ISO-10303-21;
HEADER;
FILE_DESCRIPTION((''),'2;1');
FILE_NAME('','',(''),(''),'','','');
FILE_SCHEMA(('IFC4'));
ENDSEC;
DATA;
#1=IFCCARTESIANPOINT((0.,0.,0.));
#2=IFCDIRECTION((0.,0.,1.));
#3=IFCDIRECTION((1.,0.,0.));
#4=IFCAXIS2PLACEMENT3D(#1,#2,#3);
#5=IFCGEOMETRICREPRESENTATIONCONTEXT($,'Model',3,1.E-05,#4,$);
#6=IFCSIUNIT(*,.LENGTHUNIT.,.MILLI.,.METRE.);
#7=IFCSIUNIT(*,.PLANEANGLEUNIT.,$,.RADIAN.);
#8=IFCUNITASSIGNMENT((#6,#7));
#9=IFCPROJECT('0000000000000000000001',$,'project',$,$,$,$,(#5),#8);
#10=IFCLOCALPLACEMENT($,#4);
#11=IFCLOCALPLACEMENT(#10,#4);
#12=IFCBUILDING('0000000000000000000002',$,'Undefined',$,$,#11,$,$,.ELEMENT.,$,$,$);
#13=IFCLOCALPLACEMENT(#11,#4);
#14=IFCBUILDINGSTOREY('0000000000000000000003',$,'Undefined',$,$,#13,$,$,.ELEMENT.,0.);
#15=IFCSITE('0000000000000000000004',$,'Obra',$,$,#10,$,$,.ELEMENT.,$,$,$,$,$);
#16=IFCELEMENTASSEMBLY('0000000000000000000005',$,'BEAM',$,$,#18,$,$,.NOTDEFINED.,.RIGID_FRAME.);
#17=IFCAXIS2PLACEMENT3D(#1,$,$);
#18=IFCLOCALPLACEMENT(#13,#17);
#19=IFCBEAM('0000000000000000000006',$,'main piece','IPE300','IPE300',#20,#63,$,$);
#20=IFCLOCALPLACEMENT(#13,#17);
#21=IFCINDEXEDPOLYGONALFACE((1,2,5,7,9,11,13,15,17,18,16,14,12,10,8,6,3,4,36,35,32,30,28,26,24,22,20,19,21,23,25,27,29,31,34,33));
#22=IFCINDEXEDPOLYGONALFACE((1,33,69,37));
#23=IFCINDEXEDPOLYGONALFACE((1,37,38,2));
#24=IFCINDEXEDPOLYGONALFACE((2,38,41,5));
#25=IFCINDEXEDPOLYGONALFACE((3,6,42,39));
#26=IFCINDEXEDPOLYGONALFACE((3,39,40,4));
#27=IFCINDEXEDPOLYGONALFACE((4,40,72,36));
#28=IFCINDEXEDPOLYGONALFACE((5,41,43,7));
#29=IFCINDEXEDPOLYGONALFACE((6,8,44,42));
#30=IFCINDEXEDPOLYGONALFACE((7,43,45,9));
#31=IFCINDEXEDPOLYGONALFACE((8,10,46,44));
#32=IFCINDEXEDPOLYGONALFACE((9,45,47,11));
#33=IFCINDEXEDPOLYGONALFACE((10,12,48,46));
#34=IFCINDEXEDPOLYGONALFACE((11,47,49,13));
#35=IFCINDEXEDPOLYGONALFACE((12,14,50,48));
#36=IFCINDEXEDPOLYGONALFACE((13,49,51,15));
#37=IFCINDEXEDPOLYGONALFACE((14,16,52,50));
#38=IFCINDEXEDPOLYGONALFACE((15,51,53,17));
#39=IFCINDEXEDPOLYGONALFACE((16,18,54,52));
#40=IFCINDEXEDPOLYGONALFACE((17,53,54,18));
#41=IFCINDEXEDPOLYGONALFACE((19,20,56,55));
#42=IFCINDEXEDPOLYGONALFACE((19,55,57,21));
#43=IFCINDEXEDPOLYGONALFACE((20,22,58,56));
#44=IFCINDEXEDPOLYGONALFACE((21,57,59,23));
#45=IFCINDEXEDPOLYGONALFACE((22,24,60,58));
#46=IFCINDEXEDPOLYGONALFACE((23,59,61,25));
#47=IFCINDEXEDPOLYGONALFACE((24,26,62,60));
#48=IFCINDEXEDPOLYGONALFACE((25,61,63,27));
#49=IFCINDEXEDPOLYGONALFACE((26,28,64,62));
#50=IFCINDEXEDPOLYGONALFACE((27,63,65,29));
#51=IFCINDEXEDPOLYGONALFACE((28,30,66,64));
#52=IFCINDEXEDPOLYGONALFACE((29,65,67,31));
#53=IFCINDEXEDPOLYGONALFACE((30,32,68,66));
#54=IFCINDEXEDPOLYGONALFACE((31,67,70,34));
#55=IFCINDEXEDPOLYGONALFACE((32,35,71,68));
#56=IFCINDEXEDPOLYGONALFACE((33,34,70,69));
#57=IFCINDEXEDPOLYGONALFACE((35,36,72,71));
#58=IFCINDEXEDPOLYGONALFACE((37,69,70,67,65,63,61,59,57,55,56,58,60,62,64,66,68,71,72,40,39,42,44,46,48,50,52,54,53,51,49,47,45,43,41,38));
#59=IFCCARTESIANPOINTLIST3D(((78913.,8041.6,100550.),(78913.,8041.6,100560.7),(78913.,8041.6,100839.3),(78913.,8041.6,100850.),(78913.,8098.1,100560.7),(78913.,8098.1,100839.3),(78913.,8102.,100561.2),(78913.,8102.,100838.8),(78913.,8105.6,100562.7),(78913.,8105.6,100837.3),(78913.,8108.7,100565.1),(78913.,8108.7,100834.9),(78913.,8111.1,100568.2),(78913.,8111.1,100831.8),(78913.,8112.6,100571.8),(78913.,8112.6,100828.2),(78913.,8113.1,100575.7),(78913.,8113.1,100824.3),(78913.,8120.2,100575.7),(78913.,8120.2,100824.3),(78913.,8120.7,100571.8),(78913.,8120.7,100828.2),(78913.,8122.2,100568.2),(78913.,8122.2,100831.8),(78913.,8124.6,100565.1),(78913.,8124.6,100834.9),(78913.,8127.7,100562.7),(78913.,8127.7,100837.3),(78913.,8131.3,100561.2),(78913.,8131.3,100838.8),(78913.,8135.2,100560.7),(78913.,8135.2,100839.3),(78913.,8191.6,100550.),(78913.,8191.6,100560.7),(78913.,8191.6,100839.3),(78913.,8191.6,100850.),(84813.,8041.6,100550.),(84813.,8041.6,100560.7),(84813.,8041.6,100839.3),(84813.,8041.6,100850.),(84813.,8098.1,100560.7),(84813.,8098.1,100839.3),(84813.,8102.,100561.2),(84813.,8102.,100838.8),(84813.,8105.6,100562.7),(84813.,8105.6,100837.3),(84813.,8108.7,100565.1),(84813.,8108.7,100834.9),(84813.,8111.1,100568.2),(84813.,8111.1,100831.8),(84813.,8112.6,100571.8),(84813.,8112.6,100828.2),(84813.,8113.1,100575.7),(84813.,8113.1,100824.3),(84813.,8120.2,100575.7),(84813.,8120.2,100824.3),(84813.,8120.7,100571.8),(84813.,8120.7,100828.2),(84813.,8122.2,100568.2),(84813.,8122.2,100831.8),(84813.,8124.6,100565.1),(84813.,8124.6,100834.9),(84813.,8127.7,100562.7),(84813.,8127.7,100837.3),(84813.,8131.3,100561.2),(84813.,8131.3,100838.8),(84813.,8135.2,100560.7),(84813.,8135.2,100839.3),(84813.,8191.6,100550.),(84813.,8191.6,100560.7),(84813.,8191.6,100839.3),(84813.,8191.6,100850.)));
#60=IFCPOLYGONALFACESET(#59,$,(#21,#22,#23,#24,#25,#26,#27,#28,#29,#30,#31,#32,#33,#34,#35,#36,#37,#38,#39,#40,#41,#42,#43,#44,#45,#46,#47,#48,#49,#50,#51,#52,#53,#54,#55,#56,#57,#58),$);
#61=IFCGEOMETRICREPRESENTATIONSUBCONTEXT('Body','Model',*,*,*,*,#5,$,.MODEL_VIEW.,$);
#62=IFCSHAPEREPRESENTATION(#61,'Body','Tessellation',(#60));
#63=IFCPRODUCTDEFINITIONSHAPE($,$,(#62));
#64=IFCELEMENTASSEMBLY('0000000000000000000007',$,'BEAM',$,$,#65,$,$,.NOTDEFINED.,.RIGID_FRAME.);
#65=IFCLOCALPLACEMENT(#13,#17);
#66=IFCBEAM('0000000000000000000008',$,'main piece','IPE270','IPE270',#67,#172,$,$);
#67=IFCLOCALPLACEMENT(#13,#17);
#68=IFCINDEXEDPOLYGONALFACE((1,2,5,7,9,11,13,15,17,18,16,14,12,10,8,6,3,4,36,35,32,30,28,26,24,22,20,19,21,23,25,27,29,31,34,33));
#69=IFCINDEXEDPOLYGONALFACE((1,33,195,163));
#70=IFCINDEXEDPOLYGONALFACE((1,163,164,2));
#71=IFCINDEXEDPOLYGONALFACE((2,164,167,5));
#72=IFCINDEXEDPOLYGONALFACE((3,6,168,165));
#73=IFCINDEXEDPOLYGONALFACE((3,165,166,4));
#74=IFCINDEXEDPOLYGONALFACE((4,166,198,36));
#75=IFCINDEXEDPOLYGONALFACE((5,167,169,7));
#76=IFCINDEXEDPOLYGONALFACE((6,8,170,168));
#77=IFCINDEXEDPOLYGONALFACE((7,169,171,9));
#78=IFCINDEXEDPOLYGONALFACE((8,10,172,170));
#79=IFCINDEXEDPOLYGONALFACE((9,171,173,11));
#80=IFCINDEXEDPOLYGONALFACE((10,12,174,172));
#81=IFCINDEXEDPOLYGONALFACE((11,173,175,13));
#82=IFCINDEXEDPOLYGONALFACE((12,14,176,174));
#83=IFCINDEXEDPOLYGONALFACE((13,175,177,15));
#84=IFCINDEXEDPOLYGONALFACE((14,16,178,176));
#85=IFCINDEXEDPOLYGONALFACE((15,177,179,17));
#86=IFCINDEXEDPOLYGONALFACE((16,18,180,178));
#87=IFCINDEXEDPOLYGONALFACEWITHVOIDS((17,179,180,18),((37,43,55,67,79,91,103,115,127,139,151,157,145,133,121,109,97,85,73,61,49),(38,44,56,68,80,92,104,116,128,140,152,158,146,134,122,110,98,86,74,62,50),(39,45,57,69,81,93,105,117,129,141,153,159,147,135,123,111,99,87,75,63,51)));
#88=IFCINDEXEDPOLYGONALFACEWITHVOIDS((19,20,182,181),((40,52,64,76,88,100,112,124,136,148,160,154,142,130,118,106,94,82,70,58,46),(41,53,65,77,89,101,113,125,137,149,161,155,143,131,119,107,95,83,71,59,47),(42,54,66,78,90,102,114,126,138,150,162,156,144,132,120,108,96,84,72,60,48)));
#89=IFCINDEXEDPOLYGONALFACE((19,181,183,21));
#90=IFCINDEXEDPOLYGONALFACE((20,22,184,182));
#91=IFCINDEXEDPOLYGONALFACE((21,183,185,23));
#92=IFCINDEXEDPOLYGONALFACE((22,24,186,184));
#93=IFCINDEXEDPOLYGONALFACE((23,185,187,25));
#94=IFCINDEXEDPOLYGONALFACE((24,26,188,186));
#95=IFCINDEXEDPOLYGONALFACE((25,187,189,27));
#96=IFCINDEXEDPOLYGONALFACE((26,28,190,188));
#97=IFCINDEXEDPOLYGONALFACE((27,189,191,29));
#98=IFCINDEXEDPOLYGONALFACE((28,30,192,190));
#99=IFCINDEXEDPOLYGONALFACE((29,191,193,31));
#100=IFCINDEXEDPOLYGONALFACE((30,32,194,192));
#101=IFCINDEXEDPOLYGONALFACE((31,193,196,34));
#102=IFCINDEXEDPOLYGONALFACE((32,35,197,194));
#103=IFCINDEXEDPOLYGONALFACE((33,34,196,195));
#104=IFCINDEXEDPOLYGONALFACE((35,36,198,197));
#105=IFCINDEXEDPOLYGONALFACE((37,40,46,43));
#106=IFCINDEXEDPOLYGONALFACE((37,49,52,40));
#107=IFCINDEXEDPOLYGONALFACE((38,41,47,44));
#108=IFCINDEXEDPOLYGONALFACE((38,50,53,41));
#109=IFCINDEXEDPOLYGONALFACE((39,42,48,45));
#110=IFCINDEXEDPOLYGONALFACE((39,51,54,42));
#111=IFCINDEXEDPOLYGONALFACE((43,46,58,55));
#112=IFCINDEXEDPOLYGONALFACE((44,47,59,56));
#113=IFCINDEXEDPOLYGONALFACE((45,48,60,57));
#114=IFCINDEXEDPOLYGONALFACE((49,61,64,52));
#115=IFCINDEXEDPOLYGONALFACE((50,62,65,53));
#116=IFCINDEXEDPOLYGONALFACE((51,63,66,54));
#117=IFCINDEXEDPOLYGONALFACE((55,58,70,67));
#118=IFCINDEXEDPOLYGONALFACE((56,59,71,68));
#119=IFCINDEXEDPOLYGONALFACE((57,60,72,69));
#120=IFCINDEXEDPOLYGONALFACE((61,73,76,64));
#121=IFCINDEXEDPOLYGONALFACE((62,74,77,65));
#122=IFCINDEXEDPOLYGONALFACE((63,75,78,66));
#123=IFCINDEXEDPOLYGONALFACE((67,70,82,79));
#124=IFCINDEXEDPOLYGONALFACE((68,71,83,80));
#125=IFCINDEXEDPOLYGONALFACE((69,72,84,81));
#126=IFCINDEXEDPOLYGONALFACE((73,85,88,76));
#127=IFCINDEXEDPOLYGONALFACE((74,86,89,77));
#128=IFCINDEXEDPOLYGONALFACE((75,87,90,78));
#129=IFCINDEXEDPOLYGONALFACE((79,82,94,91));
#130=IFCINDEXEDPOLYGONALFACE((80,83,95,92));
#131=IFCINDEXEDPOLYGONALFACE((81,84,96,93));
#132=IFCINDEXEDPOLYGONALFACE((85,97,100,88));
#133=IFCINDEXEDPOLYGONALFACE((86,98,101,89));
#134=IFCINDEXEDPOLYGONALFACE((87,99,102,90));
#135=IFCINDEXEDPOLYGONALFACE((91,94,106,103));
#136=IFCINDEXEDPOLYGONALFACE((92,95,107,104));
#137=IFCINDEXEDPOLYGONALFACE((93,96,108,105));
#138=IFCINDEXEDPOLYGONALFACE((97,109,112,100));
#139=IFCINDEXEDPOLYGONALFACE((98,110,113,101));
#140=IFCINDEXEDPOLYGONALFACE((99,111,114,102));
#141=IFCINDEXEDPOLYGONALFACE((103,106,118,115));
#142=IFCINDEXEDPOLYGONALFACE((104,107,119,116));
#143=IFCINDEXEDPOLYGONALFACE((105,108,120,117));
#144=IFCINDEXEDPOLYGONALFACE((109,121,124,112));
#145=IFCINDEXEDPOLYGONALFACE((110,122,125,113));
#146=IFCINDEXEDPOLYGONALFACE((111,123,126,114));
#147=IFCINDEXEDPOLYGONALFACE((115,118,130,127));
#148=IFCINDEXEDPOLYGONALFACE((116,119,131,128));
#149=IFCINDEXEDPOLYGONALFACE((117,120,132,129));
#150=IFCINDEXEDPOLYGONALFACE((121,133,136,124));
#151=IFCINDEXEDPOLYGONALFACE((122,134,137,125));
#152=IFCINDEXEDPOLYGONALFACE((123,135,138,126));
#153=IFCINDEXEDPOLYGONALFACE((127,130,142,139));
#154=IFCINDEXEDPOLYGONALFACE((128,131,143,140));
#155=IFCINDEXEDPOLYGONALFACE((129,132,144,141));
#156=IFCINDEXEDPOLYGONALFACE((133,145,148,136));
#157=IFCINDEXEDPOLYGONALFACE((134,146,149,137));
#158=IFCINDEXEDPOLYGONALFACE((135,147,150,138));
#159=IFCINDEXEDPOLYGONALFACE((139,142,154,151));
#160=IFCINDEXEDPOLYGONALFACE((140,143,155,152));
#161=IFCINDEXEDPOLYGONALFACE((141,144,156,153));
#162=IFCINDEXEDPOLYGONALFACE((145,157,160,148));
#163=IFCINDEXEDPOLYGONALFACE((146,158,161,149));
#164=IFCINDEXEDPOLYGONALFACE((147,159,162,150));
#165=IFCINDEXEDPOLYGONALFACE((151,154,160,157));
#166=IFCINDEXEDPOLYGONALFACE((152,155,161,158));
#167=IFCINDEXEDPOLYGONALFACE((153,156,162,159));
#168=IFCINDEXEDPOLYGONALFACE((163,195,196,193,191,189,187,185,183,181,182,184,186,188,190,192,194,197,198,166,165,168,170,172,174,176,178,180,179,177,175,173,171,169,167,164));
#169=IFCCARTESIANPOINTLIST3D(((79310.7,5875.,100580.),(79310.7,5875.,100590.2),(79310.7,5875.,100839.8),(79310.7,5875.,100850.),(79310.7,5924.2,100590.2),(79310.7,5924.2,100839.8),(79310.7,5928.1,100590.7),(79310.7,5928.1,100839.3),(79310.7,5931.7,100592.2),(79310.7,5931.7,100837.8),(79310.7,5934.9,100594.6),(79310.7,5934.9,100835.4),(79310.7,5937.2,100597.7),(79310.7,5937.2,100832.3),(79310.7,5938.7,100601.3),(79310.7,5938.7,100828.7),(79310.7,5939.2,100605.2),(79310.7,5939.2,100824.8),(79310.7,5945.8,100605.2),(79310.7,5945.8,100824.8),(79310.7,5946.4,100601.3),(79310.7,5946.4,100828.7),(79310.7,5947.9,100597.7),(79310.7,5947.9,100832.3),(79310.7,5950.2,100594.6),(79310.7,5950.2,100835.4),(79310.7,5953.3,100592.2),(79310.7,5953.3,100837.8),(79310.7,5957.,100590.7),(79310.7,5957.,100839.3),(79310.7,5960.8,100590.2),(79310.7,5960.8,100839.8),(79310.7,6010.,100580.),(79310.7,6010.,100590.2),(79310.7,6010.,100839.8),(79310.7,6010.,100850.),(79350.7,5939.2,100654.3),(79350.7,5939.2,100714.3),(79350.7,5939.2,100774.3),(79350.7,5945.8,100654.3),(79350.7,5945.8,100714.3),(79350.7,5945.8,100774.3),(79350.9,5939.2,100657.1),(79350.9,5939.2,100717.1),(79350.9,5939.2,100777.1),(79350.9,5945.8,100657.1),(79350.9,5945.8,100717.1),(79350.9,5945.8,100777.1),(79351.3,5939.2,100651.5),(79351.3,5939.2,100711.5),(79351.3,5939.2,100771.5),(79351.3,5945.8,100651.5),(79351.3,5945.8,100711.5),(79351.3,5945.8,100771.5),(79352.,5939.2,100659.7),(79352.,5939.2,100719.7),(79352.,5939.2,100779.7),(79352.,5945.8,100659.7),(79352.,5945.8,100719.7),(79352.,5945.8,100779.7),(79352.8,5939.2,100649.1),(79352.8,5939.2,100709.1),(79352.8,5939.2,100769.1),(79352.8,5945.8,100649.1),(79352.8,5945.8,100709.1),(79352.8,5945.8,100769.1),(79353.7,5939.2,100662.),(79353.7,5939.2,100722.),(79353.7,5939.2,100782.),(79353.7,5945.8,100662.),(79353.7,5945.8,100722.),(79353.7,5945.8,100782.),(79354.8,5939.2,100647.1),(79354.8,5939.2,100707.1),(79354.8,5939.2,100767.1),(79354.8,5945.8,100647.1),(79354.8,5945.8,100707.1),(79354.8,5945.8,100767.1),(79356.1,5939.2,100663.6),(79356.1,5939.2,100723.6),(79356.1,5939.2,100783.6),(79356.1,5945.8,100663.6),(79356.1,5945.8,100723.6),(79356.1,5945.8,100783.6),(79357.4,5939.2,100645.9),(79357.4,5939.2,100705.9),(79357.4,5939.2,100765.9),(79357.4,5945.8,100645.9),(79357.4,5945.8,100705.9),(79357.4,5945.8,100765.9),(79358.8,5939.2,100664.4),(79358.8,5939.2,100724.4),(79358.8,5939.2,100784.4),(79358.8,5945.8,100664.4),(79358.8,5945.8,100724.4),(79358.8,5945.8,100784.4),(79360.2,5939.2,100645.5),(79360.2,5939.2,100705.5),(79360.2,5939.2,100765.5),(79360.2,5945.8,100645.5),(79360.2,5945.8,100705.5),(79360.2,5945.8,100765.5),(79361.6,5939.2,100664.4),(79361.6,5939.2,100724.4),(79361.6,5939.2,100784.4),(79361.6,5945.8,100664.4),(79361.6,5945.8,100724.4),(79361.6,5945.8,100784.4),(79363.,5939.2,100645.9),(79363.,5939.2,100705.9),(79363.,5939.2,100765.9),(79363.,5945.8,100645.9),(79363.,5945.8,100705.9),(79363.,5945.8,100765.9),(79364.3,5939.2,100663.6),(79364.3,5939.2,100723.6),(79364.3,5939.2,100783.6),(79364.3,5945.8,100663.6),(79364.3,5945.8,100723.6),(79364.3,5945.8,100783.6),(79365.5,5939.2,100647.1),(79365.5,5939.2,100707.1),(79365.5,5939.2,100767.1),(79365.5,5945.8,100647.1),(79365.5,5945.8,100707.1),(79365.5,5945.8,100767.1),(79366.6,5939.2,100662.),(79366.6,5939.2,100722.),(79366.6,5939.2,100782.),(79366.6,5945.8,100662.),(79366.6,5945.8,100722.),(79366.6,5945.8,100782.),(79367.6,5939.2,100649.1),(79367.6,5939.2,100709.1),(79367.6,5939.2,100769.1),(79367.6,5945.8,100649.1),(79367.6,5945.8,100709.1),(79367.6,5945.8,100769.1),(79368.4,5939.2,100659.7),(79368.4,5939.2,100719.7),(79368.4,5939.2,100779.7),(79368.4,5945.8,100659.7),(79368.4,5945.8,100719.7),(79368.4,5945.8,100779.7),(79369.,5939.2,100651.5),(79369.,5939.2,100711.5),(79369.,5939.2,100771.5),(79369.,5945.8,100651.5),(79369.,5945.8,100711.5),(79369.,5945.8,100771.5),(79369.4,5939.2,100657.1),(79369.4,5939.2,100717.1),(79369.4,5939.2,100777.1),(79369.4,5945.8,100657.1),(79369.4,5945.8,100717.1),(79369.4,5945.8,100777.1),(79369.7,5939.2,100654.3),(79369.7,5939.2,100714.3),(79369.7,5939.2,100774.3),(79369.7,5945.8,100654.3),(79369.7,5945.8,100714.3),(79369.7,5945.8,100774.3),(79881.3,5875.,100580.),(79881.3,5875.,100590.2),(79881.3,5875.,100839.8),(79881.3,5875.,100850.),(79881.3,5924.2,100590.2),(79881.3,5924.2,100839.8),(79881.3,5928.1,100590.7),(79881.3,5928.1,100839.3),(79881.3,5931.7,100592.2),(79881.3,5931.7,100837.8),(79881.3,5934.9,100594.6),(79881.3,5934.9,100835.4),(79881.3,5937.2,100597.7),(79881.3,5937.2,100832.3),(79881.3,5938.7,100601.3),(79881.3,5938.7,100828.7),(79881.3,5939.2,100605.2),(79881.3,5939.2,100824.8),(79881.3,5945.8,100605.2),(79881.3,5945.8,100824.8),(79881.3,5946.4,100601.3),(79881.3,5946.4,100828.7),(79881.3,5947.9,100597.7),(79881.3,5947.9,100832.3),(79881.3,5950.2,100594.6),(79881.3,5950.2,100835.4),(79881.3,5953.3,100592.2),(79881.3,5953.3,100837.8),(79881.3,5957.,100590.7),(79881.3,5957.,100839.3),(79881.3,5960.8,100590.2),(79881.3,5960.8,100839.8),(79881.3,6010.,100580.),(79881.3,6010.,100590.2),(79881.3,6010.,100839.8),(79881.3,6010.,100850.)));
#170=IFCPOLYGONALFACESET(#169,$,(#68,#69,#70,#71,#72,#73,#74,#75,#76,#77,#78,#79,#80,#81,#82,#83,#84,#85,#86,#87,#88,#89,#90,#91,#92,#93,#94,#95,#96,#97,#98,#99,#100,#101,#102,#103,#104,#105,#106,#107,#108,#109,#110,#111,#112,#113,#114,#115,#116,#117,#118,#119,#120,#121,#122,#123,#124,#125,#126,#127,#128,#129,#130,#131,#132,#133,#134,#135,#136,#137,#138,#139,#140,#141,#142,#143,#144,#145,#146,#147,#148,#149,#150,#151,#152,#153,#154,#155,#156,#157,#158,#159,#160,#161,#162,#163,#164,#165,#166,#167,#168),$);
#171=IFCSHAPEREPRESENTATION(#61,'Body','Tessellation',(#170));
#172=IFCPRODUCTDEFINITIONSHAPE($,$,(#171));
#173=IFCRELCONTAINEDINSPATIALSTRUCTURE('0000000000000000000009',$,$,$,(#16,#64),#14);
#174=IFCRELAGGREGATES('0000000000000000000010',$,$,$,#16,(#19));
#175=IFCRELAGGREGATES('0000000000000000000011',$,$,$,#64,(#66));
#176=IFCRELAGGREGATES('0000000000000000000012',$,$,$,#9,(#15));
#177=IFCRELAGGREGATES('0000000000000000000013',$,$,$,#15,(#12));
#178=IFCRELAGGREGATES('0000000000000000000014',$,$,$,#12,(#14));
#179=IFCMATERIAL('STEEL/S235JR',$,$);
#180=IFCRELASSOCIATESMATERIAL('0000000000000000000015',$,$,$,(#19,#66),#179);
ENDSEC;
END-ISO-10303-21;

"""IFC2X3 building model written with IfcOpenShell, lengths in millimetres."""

from ifc_helpers import new_model, si_unit, frame, origin_with_axes, origin_2d_with_axis, place, context, subcontext, project, spatial, circle, i_section, extrude, clip, halfspace, source, transform, mapped, material, element, aggregate, save


model = new_model("IFC2X3")

# Units and contexts
model_context = context("Model", 3, precision=1e-05, world=origin_with_axes())
body_context = subcontext(model_context, "Body", "Model", "MODEL_VIEW")
ifc_project = project(units=[si_unit("LENGTHUNIT", "METRE", prefix="MILLI"), si_unit("PLANEANGLEUNIT", "RADIAN")], contexts=[model_context])

# Site, building, storey
site_placement = place(None, origin_with_axes())
site = spatial("IfcSite", under=ifc_project, at=site_placement, Name="Obra", CompositionType="ELEMENT")
building_placement = place(site_placement, origin_with_axes())
building = spatial("IfcBuilding", under=site, at=building_placement, Name="Undefined", CompositionType="ELEMENT")
storey_placement = place(building_placement, origin_with_axes())
storey = spatial("IfcBuildingStorey", under=building, at=storey_placement, Name="Undefined", CompositionType="ELEMENT", Elevation=0.0)

# Shared definitions
ifc_material = material(Name="STEEL/S235JR")

# Element assembly, beam
assembly_1_placement = place(storey_placement, origin_with_axes())
assembly_1 = element("IfcElementAssembly", 1, at=assembly_1_placement, inside=storey, Name="BEAM", AssemblyPlace="NOTDEFINED", PredefinedType="RIGID_FRAME")
beam_1_placement = place(assembly_1_placement, frame((78913.0, 8116.6, 100700.0), z_axis=(0.0, 0.0, 1.0), x_axis=(1.0, 0.0, 0.0)))
beam_1 = element("IfcBeam", 2, at=beam_1_placement, material=ifc_material, Name="main piece", Description="IPE300", ObjectType="IPE300", context=body_context, shape_type="SweptSolid", body=[
    extrude(i_section(OverallWidth=150.0, OverallDepth=300.0, WebThickness=7.1, FlangeThickness=10.7, FilletRadius=15.0, at=origin_2d_with_axis()), frame((5900.0, 0.0, 0.0), z_axis=(-1.0, 0.0, 0.0), x_axis=(0.0, -1.0, 0.0)), (0.0, 0.0, 1.0), 5900.0),
])
aggregate(assembly_1, [beam_1])

# Element assembly, beam, opening
assembly_2_placement = place(storey_placement, origin_with_axes())
assembly_2 = element("IfcElementAssembly", 3, at=assembly_2_placement, inside=storey, Name="BEAM", AssemblyPlace="NOTDEFINED", PredefinedType="RIGID_FRAME")
beam_2_placement = place(assembly_2_placement, frame((78913.0, 5942.5, 100715.0), z_axis=(0.0, 0.0, 1.0), x_axis=(1.0, 0.0, 0.0)))
beam_2 = element("IfcBeam", 4, at=beam_2_placement, material=ifc_material, Name="main piece", Description="IPE270", ObjectType="IPE270", context=body_context, shape_type="Clipping", body=[
    clip(extrude(i_section(OverallWidth=135.0, OverallDepth=270.0, WebThickness=6.6, FlangeThickness=10.2, FilletRadius=15.0, at=origin_2d_with_axis()), frame((968.3, 0.0, 0.0), z_axis=(-1.0, 0.0, 0.0), x_axis=(0.0, -1.0, 0.0)), (0.0, 0.0, 1.0), 968.3), halfspace(frame((397.6, 60.0, -120.0), z_axis=(-1.0, -0.000017, 0.0), x_axis=(0.0, 0.0, 1.0)), False)),
])
shared_shape_1 = source(origin_with_axes(), body_context, "Body", "SweptSolid", [
    extrude(circle(Radius=9.5, at=origin_2d_with_axis()), frame((0.0, -3.4, 0.0), z_axis=(0.0, 1.0, 0.0), x_axis=(1.0, 0.0, 0.0)), (0.0, 0.0, 1.0), 6.8),
])
opening_1_placement = place(assembly_2_placement, frame((79310.2, 5942.5, 100835.0), z_axis=(1.0, 0.0, 0.0), x_axis=(0.0, 0.0, -1.0)))
element("IfcOpeningElement", 5, at=opening_1_placement, cuts=beam_2, ObjectType="Opening", context=body_context, shape_type="MappedRepresentation", body=[
    mapped(shared_shape_1, transform((60.0, 0.0, 50.0))),
    mapped(shared_shape_1, transform((120.0, 0.0, 50.0))),
    mapped(shared_shape_1, transform((180.0, 0.0, 50.0))),
])
aggregate(assembly_2, [beam_2])

save(model, "model.ifc")
